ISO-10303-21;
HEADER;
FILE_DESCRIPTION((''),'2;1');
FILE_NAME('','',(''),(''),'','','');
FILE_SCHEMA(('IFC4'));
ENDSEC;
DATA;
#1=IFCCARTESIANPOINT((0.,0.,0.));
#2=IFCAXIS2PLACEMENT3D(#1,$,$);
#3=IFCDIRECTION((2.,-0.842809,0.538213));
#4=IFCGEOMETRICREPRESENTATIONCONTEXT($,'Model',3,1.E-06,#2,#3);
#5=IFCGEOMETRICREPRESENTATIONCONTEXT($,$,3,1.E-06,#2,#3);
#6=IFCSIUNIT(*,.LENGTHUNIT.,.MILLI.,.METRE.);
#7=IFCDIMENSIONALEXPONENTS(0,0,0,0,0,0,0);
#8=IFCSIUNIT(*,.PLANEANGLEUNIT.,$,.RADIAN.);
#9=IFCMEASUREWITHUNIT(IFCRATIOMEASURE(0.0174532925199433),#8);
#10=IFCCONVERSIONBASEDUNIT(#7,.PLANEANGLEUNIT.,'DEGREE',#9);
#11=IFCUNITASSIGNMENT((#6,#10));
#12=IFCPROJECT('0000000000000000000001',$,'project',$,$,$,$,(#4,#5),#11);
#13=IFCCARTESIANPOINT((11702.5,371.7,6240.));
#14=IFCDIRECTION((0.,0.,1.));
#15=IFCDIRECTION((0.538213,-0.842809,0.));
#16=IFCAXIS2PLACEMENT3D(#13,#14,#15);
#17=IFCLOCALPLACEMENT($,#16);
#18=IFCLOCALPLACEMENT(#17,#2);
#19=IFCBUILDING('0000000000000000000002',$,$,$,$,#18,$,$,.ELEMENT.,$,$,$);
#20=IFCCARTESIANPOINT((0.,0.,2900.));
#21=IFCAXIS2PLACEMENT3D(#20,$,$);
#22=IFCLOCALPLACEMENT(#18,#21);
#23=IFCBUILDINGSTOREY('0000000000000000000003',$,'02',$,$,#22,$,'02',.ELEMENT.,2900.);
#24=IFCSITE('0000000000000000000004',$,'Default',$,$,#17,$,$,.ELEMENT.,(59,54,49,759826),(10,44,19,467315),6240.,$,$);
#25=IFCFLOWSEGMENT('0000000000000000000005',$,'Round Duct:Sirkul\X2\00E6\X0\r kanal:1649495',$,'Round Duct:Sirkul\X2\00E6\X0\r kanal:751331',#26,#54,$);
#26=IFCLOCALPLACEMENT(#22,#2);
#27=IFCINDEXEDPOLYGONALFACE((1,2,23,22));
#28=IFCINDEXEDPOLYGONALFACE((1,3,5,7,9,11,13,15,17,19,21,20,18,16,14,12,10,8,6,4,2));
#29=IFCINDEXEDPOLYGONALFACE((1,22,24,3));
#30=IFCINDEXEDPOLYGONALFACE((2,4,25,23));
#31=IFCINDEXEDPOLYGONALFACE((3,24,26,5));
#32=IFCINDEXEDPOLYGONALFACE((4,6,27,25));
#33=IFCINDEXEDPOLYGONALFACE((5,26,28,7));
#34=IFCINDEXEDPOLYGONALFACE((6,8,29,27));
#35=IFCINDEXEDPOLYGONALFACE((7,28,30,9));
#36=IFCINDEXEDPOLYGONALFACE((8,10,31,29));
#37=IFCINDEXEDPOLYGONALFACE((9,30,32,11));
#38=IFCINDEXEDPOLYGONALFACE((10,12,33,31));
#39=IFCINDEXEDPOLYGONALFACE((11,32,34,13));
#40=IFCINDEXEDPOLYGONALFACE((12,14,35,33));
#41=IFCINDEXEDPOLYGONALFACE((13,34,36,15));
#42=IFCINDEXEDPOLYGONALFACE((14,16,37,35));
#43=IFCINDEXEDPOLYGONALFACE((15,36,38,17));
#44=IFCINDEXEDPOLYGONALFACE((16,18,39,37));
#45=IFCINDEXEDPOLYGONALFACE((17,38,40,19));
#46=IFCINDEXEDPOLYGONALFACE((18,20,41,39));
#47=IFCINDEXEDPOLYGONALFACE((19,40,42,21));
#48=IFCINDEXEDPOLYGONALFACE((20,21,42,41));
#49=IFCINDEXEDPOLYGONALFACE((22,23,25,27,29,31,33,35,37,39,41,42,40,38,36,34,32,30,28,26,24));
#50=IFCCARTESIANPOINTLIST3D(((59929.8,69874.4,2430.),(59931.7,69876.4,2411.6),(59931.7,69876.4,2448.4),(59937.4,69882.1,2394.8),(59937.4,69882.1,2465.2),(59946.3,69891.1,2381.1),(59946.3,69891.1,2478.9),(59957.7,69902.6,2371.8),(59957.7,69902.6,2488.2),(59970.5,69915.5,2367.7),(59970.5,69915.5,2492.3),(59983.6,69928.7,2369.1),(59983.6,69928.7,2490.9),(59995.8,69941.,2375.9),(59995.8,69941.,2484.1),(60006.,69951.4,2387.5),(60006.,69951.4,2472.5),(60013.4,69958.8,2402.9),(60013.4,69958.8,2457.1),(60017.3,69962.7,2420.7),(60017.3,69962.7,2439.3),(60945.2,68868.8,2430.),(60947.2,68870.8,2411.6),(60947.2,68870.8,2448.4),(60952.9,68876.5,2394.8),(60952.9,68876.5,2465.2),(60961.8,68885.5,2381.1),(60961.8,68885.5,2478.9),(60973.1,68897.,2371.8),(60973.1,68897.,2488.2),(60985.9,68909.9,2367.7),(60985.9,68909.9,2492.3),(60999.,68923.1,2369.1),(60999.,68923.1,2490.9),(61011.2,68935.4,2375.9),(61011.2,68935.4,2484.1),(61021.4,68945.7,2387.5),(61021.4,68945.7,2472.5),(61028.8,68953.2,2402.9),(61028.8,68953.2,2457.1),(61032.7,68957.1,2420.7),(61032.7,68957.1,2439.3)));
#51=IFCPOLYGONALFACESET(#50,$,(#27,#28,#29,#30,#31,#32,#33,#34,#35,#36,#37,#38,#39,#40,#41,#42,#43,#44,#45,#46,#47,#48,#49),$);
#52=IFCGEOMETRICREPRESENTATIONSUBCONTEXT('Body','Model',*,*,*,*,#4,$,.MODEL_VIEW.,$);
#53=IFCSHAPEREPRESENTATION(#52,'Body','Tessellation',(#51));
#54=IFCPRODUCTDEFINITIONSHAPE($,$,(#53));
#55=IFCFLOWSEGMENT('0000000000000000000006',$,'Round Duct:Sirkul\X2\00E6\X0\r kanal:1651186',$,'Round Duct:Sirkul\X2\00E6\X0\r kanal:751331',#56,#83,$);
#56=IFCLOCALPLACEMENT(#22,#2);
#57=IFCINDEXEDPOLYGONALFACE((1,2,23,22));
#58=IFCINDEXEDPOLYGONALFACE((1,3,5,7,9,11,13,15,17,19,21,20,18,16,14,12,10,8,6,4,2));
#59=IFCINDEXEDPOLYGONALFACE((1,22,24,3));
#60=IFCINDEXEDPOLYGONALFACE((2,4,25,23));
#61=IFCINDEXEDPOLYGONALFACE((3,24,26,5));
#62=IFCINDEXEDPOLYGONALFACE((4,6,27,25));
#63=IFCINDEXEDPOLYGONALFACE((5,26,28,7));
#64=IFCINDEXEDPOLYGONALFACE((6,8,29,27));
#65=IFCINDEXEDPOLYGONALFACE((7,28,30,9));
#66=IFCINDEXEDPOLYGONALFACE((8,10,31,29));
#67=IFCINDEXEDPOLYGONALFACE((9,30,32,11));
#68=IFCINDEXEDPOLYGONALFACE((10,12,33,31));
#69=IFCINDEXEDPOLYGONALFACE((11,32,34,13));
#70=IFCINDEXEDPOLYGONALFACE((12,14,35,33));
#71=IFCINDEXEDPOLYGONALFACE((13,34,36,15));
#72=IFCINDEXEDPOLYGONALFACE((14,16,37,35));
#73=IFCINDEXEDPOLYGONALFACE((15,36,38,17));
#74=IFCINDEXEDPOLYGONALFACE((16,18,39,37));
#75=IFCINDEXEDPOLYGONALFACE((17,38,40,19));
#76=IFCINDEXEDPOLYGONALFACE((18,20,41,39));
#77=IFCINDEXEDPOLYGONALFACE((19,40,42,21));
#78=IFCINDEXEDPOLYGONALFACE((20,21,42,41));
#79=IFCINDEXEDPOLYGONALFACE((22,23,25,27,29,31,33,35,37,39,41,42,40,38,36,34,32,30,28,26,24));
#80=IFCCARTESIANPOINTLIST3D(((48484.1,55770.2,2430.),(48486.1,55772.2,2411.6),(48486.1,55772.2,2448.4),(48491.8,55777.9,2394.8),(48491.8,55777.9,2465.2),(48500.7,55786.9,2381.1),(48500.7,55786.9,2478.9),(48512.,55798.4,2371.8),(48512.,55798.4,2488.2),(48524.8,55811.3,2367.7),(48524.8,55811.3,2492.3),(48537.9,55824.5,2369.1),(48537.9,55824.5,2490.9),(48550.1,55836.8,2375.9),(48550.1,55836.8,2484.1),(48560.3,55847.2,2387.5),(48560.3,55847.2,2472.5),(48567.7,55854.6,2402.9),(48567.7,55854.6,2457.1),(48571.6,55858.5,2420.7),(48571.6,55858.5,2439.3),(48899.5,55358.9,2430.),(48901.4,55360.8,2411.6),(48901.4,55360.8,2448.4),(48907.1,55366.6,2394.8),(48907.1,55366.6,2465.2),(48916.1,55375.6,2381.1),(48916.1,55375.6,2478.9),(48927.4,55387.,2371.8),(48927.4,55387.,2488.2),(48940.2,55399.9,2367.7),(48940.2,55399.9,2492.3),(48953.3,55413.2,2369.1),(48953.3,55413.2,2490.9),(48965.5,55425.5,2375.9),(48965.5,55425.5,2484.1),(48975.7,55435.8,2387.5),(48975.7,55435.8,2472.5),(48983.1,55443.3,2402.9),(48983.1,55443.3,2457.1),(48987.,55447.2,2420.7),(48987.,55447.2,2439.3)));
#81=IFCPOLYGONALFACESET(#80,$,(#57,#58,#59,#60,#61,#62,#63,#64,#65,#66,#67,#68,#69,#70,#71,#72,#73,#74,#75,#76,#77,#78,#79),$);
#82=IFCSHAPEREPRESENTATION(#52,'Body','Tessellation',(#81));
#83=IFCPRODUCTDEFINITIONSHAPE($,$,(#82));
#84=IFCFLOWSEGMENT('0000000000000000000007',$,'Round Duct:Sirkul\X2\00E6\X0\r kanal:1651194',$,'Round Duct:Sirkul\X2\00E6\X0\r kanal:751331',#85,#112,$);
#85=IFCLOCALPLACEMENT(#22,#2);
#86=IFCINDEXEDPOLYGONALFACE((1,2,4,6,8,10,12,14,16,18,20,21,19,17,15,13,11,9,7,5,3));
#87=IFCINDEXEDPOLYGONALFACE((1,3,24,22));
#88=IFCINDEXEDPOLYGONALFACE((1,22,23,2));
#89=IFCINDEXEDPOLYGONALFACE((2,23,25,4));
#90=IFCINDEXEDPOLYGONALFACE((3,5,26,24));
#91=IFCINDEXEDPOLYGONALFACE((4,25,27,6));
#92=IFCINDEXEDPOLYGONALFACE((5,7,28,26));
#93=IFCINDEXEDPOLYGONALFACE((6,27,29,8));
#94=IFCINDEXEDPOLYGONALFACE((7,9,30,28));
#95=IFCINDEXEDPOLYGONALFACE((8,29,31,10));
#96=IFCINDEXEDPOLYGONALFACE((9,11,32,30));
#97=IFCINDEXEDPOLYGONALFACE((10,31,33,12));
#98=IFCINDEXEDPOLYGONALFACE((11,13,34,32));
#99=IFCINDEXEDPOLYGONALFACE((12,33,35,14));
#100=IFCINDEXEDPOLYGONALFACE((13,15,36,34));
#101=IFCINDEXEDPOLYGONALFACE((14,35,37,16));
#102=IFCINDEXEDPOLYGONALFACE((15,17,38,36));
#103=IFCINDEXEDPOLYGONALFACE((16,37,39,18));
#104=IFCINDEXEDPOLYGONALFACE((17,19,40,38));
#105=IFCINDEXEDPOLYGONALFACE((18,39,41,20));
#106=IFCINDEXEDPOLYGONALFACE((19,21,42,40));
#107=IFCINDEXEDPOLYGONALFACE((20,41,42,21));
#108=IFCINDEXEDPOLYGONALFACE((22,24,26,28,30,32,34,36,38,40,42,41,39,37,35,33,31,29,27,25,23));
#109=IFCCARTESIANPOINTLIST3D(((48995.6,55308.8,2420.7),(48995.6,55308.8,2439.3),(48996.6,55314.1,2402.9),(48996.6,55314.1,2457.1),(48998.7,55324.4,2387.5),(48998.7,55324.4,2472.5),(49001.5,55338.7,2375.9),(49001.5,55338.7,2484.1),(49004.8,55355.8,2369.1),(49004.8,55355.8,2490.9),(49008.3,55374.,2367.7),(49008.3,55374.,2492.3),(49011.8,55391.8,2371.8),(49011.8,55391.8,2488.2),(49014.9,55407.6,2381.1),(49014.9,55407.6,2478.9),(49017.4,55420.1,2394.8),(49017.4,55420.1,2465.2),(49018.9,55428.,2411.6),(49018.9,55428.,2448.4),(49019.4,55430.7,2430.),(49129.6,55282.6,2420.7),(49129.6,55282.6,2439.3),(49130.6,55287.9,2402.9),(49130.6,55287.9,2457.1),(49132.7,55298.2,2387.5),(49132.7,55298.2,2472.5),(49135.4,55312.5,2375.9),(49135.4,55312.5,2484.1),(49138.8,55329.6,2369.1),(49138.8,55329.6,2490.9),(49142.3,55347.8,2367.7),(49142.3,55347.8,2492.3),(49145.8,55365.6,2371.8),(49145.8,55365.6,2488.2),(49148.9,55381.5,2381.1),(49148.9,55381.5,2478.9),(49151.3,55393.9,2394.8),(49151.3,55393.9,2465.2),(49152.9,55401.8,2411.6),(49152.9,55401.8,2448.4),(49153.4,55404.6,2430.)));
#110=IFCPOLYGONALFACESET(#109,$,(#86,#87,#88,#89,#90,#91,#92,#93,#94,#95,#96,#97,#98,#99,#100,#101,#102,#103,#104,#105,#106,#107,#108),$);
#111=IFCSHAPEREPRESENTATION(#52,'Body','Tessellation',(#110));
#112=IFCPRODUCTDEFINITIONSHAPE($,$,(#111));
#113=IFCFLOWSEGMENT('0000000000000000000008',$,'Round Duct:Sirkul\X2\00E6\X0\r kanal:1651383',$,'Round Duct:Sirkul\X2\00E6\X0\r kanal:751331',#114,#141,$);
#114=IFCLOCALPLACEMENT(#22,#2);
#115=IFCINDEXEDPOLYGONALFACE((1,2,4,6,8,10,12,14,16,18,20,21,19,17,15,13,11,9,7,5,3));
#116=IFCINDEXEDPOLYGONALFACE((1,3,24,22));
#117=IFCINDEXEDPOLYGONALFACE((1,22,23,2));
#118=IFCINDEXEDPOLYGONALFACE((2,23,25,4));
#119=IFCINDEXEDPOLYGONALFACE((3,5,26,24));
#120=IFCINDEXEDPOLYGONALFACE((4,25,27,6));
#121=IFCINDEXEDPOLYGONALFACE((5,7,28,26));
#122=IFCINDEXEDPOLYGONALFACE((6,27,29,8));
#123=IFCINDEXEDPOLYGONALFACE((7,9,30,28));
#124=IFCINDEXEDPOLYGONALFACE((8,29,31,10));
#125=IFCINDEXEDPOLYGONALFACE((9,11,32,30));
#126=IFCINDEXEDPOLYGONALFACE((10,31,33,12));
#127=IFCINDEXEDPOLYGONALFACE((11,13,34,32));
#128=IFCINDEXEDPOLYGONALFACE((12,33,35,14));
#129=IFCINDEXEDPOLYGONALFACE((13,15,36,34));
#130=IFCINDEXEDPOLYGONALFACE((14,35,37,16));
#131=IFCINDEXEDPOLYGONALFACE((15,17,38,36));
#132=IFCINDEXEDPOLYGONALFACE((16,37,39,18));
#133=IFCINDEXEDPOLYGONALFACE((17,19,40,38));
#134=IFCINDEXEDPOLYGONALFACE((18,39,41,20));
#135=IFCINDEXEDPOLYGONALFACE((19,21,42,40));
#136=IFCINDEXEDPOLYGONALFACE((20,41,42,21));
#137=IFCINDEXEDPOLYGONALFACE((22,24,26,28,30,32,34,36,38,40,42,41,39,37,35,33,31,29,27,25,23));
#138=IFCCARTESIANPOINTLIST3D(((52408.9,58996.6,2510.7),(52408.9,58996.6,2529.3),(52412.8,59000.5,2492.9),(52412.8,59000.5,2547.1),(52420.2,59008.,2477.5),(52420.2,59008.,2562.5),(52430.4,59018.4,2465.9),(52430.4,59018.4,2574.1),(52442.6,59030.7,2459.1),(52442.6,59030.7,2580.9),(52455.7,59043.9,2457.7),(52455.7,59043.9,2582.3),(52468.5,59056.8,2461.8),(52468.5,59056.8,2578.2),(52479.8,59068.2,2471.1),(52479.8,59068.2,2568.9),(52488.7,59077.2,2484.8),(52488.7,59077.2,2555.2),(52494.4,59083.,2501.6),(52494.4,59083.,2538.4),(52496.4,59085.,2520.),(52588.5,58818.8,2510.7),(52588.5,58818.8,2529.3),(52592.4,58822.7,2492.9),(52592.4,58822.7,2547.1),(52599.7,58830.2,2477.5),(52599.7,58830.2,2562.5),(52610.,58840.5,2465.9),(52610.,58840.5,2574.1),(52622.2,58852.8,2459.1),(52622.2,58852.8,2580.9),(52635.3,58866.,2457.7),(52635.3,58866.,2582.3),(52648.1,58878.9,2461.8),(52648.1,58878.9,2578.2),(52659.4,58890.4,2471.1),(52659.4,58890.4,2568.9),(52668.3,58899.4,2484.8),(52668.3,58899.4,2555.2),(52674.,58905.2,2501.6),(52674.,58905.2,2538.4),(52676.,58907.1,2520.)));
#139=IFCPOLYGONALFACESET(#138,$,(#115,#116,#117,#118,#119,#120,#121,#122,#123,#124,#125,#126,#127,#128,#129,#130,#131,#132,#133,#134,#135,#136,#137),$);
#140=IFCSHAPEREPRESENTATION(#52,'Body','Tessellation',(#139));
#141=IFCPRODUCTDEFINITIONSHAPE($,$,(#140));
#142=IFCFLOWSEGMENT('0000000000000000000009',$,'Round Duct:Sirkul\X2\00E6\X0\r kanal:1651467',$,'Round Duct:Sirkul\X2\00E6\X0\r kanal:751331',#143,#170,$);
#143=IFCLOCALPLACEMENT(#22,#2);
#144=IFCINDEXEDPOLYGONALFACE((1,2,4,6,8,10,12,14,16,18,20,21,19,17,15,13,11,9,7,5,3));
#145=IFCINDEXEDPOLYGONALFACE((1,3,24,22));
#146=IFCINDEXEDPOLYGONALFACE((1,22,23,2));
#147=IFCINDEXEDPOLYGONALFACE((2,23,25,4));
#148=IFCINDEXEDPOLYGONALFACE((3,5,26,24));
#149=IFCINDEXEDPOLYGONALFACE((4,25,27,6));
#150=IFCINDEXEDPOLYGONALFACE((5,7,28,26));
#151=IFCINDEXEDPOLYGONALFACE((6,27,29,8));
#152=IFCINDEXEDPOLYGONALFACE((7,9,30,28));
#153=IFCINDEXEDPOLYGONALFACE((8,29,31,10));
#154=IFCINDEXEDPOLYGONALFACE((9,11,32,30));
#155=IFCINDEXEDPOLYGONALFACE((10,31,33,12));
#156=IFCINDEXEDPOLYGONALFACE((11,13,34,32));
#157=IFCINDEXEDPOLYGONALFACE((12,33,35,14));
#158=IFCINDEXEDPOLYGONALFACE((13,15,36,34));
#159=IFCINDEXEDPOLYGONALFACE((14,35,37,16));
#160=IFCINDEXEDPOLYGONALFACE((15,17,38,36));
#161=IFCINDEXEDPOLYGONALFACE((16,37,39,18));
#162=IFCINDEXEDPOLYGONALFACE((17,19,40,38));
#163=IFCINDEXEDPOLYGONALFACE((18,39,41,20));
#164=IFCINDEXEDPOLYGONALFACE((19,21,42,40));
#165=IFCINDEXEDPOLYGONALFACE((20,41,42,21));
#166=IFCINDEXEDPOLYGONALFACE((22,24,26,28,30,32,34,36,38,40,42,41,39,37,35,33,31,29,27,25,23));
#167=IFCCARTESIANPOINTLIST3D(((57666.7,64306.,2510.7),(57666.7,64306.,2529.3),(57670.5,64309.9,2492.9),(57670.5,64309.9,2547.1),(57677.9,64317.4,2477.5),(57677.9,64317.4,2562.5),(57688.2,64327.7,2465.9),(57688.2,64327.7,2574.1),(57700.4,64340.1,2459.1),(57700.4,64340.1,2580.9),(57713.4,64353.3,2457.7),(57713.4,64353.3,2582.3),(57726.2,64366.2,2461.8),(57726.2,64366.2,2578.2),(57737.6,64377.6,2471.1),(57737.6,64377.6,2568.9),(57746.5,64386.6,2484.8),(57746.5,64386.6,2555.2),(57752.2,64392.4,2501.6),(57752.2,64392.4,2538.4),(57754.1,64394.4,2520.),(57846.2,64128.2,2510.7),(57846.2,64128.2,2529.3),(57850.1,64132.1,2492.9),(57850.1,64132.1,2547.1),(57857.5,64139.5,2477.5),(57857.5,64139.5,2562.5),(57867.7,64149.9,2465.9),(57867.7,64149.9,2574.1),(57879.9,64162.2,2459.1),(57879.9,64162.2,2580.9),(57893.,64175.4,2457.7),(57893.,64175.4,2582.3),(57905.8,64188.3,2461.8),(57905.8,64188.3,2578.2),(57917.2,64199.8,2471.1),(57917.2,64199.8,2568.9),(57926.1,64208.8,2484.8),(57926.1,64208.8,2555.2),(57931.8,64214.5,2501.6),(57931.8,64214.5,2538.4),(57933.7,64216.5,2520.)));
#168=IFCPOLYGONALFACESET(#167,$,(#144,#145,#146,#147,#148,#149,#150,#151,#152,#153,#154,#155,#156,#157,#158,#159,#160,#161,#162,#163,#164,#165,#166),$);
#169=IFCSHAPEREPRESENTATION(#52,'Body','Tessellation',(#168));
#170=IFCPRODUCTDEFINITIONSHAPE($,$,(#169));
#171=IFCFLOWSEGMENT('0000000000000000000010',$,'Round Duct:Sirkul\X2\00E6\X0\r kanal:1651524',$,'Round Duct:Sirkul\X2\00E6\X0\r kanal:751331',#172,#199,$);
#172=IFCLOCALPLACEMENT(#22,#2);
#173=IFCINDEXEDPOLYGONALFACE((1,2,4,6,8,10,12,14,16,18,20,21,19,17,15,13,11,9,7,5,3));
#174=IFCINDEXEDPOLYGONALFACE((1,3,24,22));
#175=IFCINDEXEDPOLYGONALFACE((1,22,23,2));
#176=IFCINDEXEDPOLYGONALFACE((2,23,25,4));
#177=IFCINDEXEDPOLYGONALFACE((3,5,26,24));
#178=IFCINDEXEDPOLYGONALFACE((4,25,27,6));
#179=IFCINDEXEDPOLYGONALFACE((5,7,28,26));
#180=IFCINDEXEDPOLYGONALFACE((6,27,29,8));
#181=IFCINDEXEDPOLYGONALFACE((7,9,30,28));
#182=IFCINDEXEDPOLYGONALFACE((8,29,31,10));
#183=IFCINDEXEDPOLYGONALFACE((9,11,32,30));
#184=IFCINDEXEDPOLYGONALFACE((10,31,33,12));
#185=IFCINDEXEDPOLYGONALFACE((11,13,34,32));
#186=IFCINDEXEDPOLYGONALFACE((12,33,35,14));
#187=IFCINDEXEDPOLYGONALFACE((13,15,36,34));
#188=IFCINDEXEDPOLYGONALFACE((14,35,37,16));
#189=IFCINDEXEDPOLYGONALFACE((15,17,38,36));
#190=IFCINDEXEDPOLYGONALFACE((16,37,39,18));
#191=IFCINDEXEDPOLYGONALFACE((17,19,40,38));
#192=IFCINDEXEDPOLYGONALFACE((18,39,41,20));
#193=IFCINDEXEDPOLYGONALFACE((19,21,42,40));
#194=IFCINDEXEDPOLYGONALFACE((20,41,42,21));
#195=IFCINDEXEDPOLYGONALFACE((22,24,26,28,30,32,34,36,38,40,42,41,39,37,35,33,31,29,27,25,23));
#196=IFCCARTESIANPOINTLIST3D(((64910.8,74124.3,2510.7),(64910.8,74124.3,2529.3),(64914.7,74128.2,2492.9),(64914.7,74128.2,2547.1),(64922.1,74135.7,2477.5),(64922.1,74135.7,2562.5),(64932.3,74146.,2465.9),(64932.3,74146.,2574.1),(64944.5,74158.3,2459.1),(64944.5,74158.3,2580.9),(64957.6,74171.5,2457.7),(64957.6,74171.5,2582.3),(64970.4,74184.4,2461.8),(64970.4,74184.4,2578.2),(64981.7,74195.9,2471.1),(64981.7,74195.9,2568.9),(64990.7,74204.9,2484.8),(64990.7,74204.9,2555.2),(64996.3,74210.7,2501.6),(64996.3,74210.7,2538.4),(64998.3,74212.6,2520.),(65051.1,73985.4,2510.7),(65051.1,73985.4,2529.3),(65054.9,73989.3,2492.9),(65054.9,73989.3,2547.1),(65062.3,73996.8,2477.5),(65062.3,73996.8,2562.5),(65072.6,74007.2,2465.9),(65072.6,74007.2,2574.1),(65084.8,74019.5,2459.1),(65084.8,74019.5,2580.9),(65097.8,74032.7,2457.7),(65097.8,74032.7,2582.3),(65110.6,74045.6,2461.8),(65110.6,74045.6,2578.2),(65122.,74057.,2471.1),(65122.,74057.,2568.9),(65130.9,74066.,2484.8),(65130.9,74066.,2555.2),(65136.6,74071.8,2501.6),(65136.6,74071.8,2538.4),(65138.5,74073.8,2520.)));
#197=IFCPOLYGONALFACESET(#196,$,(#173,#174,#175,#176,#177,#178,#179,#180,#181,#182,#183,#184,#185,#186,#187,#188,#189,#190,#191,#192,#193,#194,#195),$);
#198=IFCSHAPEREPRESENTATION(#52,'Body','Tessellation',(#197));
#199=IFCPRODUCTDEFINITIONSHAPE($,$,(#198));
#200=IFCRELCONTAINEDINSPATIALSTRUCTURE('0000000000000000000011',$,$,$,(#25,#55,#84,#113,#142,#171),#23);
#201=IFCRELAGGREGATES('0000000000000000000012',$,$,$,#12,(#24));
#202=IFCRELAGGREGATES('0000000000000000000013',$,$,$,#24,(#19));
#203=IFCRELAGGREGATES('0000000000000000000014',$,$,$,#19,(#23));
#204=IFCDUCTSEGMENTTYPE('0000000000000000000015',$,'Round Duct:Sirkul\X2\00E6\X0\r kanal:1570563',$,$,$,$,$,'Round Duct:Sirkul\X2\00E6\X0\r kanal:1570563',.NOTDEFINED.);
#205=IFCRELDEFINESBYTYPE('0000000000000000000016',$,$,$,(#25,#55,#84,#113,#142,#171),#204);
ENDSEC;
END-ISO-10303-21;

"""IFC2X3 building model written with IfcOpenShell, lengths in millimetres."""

from ifc_helpers import new_model, entity, si_unit, converted_unit, direction, frame, frame_2d, origin, origin_2d_with_axis, place, context, subcontext, project, spatial, circle, extrude, type_object, element, save


model = new_model("IFC2X3")

# Units and contexts
model_context = context("Model", 3, precision=1e-06, world=origin(), true_north=direction((2.0, -0.842809, 0.538213)))
context_of_model = context(None, 3, precision=1e-06, world=origin(), true_north=direction((2.0, -0.842809, 0.538213)))
body_context = subcontext(model_context, "Body", "Model", "MODEL_VIEW")
ifc_project = project(units=[si_unit("LENGTHUNIT", "METRE", prefix="MILLI"), converted_unit("PLANEANGLEUNIT", "DEGREE", entity("IfcRatioMeasure", 0.0174532925199433), si_unit("PLANEANGLEUNIT", "RADIAN"), dimensions=[0, 0, 0, 0, 0, 0, 0])], contexts=[model_context, context_of_model])

# Site, building, storey
site_placement = place(None, frame((11702.5, 371.7, 6240.0), z_axis=(0.0, 0.0, 1.0), x_axis=(0.538213, -0.842809, 0.0)))
site = spatial("IfcSite", under=ifc_project, at=site_placement, Name="Default", CompositionType="ELEMENT", RefLatitude=(59, 54, 49, 759826), RefLongitude=(10, 44, 19, 467315), RefElevation=6240.0)
building_placement = place(site_placement, origin())
building = spatial("IfcBuilding", under=site, at=building_placement, CompositionType="ELEMENT")
storey_placement = place(building_placement, frame((0.0, 0.0, 2900.0)))
storey = spatial("IfcBuildingStorey", under=building, at=storey_placement, Name="02", LongName="02", CompositionType="ELEMENT", Elevation=2900.0)

# Flow segments
duct_segment_type = type_object("IfcDuctSegmentType", Name="Round Duct:Sirkulær kanal:1570563", ElementType="Round Duct:Sirkulær kanal:1570563", PredefinedType="NOTDEFINED")
flow_segment_1_placement = place(storey_placement, origin())
element("IfcFlowSegment", 1, at=flow_segment_1_placement, inside=storey, type_object=duct_segment_type, Name="Round Duct:Sirkulær kanal:1649495", ObjectType="Round Duct:Sirkulær kanal:751331", context=body_context, shape_type="SweptSolid", body=[
    extrude(circle(Radius=62.5, at=frame_2d((0.0, 0.0), x_axis=(1.0, 0.0))), frame((60989.2, 68913.2, 2430.0), z_axis=(-0.710538, 0.703658, 0.0), x_axis=(-0.703658, -0.710538, 0.0)), (0.0, 0.0, 1.0), 1429.1),
])
flow_segment_2_placement = place(storey_placement, origin())
element("IfcFlowSegment", 2, at=flow_segment_2_placement, inside=storey, type_object=duct_segment_type, Name="Round Duct:Sirkulær kanal:1651186", ObjectType="Round Duct:Sirkulær kanal:751331", context=body_context, shape_type="SweptSolid", body=[
    extrude(circle(Radius=62.5, at=origin_2d_with_axis()), frame((48943.5, 55403.3, 2430.0), z_axis=(-0.710521, 0.703676, 0.0), x_axis=(-0.703676, -0.710521, 0.0)), (0.0, 0.0, 1.0), 584.6),
])
flow_segment_3_placement = place(storey_placement, origin())
element("IfcFlowSegment", 3, at=flow_segment_3_placement, inside=storey, type_object=duct_segment_type, Name="Round Duct:Sirkulær kanal:1651194", ObjectType="Round Duct:Sirkulær kanal:751331", context=body_context, shape_type="SweptSolid", body=[
    extrude(circle(Radius=62.5, at=origin_2d_with_axis()), frame((49141.4, 55343.2, 2430.0), z_axis=(-0.981427, 0.191834, 0.0), x_axis=(0.191834, 0.981427, 0.0)), (0.0, 0.0, 1.0), 136.5),
])
flow_segment_4_placement = place(storey_placement, origin())
element("IfcFlowSegment", 4, at=flow_segment_4_placement, inside=storey, type_object=duct_segment_type, Name="Round Duct:Sirkulær kanal:1651383", ObjectType="Round Duct:Sirkulær kanal:751331", context=body_context, shape_type="SweptSolid", body=[
    extrude(circle(Radius=62.5, at=origin_2d_with_axis()), frame((52452.4, 59040.6, 2520.0), z_axis=(0.710554, -0.703643, 0.0), x_axis=(0.703643, 0.710554, 0.0)), (0.0, 0.0, 1.0), 252.7),
])
flow_segment_5_placement = place(storey_placement, origin())
element("IfcFlowSegment", 5, at=flow_segment_5_placement, inside=storey, type_object=duct_segment_type, Name="Round Duct:Sirkulær kanal:1651467", ObjectType="Round Duct:Sirkulær kanal:751331", context=body_context, shape_type="SweptSolid", body=[
    extrude(circle(Radius=62.5, at=origin_2d_with_axis()), frame((57710.1, 64349.9, 2520.0), z_axis=(0.710554, -0.703643, 0.0), x_axis=(0.703643, 0.710554, 0.0)), (0.0, 0.0, 1.0), 252.7),
])
flow_segment_6_placement = place(storey_placement, origin())
element("IfcFlowSegment", 6, at=flow_segment_6_placement, inside=storey, type_object=duct_segment_type, Name="Round Duct:Sirkulær kanal:1651524", ObjectType="Round Duct:Sirkulær kanal:751331", context=body_context, shape_type="SweptSolid", body=[
    extrude(circle(Radius=62.5, at=frame_2d((0.0, 0.0), x_axis=(1.0, 0.0))), frame((65094.6, 74029.4, 2520.0), z_axis=(-0.710554, 0.703643, 0.0), x_axis=(0.703643, 0.710554, 0.0)), (0.0, 0.0, 1.0), 197.4),
])

save(model, "model.ifc")
